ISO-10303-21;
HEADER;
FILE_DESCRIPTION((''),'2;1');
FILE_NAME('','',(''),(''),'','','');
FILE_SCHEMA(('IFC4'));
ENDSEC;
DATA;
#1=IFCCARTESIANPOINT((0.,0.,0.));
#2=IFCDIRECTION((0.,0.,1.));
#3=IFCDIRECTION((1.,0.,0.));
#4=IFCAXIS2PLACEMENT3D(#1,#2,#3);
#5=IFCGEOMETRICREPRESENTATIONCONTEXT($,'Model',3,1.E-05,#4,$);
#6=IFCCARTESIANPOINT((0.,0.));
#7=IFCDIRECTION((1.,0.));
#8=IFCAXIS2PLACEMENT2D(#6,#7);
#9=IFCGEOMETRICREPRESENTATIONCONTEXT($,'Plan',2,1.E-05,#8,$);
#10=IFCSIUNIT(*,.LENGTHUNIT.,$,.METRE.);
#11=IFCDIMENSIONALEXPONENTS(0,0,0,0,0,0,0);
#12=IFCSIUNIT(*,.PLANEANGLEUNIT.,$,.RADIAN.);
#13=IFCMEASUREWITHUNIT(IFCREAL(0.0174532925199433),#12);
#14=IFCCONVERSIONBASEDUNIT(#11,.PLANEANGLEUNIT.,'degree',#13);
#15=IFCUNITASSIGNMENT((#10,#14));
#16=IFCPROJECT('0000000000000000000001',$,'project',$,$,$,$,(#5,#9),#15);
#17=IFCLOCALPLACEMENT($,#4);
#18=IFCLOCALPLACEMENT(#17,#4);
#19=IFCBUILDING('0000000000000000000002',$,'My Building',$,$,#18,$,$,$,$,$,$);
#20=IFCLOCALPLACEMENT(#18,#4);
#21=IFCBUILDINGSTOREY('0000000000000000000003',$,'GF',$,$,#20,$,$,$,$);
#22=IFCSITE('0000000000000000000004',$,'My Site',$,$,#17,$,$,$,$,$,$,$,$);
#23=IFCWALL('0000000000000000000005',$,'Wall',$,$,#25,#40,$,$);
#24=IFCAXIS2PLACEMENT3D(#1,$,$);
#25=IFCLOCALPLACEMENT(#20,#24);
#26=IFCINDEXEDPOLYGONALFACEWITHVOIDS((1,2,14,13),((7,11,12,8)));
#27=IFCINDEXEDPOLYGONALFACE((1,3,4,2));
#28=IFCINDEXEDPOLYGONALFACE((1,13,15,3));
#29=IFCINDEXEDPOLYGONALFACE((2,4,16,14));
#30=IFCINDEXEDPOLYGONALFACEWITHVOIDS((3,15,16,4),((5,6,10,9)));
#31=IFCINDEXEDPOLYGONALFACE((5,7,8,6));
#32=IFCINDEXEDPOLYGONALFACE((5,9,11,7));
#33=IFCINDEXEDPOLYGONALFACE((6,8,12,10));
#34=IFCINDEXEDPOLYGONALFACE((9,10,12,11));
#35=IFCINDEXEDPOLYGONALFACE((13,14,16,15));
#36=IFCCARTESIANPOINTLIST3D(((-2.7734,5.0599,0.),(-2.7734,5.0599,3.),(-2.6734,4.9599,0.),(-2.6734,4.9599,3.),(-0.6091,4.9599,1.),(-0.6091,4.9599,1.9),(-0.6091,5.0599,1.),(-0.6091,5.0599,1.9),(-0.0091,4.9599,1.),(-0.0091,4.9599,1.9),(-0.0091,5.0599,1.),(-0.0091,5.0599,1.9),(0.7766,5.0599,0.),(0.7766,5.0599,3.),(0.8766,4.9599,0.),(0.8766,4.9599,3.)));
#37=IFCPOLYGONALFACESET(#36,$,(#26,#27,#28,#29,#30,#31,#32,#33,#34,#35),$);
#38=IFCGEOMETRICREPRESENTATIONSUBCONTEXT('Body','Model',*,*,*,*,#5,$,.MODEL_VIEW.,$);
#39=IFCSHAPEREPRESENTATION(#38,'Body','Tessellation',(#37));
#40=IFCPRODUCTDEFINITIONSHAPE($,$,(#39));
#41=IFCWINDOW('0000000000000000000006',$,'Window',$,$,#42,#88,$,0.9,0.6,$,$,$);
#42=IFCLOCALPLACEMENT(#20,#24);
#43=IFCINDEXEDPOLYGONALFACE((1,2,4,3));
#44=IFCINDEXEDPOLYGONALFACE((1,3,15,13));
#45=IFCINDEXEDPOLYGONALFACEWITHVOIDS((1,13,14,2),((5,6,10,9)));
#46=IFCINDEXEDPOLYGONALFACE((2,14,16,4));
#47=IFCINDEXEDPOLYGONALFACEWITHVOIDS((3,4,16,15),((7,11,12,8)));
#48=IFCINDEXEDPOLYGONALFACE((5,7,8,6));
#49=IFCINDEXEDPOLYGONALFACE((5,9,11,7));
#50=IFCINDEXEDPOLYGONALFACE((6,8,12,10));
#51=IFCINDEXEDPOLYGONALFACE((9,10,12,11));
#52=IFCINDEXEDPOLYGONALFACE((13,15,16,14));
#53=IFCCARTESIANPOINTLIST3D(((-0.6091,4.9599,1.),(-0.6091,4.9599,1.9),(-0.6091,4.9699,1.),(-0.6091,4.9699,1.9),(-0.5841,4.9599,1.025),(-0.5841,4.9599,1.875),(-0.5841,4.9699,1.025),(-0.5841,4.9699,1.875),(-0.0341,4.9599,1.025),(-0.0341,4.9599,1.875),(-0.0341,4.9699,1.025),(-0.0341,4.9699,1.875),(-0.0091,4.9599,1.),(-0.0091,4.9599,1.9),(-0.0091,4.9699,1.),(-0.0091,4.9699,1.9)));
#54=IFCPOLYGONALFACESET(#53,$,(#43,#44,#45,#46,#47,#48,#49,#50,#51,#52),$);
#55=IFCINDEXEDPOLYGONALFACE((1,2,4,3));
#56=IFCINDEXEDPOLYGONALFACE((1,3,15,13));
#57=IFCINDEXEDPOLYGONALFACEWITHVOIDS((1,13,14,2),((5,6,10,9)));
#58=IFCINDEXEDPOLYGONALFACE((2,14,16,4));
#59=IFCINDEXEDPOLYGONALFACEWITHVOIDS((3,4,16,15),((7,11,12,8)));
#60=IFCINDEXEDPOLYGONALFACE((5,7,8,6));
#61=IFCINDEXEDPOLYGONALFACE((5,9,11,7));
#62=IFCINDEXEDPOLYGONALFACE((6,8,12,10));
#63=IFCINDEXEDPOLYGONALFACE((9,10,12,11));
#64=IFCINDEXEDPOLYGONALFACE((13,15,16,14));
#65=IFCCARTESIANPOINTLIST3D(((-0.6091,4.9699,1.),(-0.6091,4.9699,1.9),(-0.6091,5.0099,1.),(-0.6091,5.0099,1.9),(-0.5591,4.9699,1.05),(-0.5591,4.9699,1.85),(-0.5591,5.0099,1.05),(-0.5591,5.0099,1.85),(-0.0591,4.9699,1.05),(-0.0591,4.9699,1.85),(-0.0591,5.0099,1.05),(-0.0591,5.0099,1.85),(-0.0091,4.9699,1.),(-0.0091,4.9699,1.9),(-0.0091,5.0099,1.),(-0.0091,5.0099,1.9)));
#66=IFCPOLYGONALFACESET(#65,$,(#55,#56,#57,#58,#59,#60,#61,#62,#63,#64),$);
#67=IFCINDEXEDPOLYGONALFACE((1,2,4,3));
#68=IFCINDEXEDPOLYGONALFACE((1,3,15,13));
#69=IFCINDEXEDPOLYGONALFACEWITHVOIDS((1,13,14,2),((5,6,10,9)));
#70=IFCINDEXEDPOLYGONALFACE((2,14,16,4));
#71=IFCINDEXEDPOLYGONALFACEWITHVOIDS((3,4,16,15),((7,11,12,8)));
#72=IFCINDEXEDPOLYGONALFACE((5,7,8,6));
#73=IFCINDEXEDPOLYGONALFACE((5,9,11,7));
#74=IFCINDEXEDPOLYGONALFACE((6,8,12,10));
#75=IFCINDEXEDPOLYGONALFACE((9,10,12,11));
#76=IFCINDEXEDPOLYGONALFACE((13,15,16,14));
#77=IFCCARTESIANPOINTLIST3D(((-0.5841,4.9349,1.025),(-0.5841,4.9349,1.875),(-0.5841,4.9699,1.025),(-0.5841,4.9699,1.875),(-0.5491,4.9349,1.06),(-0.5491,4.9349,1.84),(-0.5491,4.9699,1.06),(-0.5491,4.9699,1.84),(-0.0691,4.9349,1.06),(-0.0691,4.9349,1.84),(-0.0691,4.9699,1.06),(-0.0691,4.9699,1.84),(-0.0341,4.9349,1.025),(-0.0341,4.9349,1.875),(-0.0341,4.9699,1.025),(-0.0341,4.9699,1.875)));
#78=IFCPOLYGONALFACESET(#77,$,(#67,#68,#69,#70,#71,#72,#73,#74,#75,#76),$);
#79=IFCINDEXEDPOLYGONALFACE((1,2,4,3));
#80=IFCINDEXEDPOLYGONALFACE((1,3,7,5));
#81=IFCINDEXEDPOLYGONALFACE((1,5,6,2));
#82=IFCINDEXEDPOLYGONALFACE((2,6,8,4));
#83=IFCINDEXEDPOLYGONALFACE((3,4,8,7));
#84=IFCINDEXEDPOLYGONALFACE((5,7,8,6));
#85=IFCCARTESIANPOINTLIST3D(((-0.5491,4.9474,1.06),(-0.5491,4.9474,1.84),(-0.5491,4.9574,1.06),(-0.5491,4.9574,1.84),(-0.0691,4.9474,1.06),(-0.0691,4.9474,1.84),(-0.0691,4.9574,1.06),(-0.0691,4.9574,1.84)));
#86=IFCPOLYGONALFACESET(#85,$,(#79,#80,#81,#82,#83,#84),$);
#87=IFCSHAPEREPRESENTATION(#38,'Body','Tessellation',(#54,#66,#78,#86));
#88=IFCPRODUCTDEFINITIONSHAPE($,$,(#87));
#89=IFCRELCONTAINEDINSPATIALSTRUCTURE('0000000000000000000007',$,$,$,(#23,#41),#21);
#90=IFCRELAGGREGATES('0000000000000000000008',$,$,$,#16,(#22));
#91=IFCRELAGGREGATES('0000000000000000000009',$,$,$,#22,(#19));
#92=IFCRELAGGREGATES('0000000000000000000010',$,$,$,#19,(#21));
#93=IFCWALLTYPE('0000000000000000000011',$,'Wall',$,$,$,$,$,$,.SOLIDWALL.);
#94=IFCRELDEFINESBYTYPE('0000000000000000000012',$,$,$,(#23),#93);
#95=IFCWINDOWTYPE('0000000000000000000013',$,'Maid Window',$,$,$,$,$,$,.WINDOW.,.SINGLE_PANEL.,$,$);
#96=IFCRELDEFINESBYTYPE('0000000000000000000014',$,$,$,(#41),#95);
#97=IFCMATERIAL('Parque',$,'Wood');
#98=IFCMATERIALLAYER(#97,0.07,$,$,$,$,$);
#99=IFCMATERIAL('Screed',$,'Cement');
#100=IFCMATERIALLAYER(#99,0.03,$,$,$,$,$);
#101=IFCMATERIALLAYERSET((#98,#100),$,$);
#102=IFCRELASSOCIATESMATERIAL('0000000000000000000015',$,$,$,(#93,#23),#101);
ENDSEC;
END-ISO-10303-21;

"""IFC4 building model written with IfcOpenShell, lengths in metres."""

from ifc_helpers import new_model, entity, si_unit, converted_unit, frame, origin_with_axes, origin_2d_with_axis, place, context, subcontext, project, spatial, line, indexed_curve, outline, extrude, shape, source, transform, mapped, material, layer, layer_set, layer_usage, type_object, type_shapes, element, fill, save


model = new_model("IFC4")

# Units and contexts
model_context = context("Model", 3, precision=1e-05, world=origin_with_axes())
plan_context = context("Plan", 2, precision=1e-05, world=origin_2d_with_axis())
body_context_1 = subcontext(model_context, "Body", "Model", "MODEL_VIEW")
body_context_2 = subcontext(plan_context, "Body", "Plan", "PLAN_VIEW")
ifc_project = project(units=[si_unit("LENGTHUNIT", "METRE"), converted_unit("PLANEANGLEUNIT", "degree", entity("IfcReal", 0.0174532925199433), si_unit("PLANEANGLEUNIT", "RADIAN"), dimensions=[0, 0, 0, 0, 0, 0, 0])], contexts=[model_context, plan_context])

# Site, building, storey
site_placement = place(None, origin_with_axes())
site = spatial("IfcSite", under=ifc_project, at=site_placement, Name="My Site")
building_placement = place(site_placement, origin_with_axes())
building = spatial("IfcBuilding", under=site, at=building_placement, Name="My Building")
storey_placement = place(building_placement, origin_with_axes())
storey = spatial("IfcBuildingStorey", under=building, at=storey_placement, Name="GF")

# Shared definitions
ifc_material_1 = material(Name="Parque", Category="Wood")
ifc_layer_1 = layer(ifc_material_1, 0.07)
ifc_material_2 = material(Name="Screed", Category="Cement")
ifc_layer_2 = layer(ifc_material_2, 0.03)
ifc_layer_set_1 = layer_set([ifc_layer_1, ifc_layer_2])
wall_type = type_object("IfcWallType", Name="Wall", PredefinedType="SOLIDWALL", material=ifc_layer_set_1)

# Wall, opening, window
ifc_layer_usage_1 = layer_usage(ifc_layer_set_1, "AXIS2", "POSITIVE", 0.0)
wall_1_placement = place(storey_placement, frame((0.7766, 5.0599, 0.0), z_axis=(0.0, 0.0, 1.0), x_axis=(-1.0, 0.0, 0.0)))
wall_1 = element("IfcWall", 1, at=wall_1_placement, inside=storey, type_object=wall_type, material=ifc_layer_usage_1, Name="Wall", context=body_context_1, shape_type="SweptSolid", body=[
    extrude(outline(indexed_curve([(0.0, 0.0), (-0.1, 0.1), (3.45, 0.1), (3.55, 0.0)], segments=[line(1, 2, 3, 4, 1)])), origin_with_axes(), (0.0, 0.0, 1.0), 3.0),
])
shared_shape_1 = source(origin_with_axes(), body_context_1, "Body", "SweptSolid", [
    extrude(outline(indexed_curve([(0.0, 0.0), (0.6, 0.0), (0.6, 0.9), (0.0, 0.9)], segments=[line(1, 2, 3, 4, 1)])), frame((0.0, -0.6, 0.0), z_axis=(0.0, -1.0, 0.0), x_axis=(1.0, 0.0, 0.0)), (0.0, 0.0, -1.0), 1.2),
])
opening_1_placement = place(wall_1_placement, frame((0.7857, 0.0, 1.0), z_axis=(0.0, 0.0, 1.0), x_axis=(1.0, 0.0, 0.0)))
opening_1 = element("IfcOpeningElement", 2, at=opening_1_placement, cuts=wall_1, PredefinedType="OPENING", context=body_context_1, shape_type="MappedRepresentation", body=[
    mapped(shared_shape_1, transform((0.0, 0.0, 0.0), x_axis=(1.0, 0.0, 0.0), y_axis=(0.0, 1.0, 0.0), z_axis=(0.0, 0.0, 1.0), scale=1.0)),
])
window_type_1 = type_object("IfcWindowType", Name="Maid Window", PartitioningType="SINGLE_PANEL", PredefinedType="WINDOW")
shared_shape_2 = source(origin_with_axes(), body_context_1, "Body", "SweptSolid", [
    extrude(outline(indexed_curve([(0.0, 0.0), (0.6, 0.0), (0.6, 0.9), (0.0, 0.9)], segments=[line(1, 2, 3, 4, 1)]), holes=[indexed_curve([(0.025, 0.025), (0.575, 0.025), (0.575, 0.875), (0.025, 0.875)], segments=[line(1, 2, 3, 4, 1)])]), frame((0.0, 0.09, 0.0), z_axis=(0.0, -1.0, 0.0), x_axis=(1.0, 0.0, 0.0)), (0.0, 0.0, -1.0), 0.01),
    extrude(outline(indexed_curve([(0.0, 0.0), (0.6, 0.0), (0.6, 0.9), (0.0, 0.9)], segments=[line(1, 2, 3, 4, 1)]), holes=[indexed_curve([(0.05, 0.05), (0.55, 0.05), (0.55, 0.85), (0.05, 0.85)], segments=[line(1, 2, 3, 4, 1)])]), frame((0.0, 0.05, 0.0), z_axis=(0.0, -1.0, 0.0), x_axis=(1.0, 0.0, 0.0)), (0.0, 0.0, -1.0), 0.04),
    extrude(outline(indexed_curve([(0.0, 0.0), (0.55, 0.0), (0.55, 0.85), (0.0, 0.85)], segments=[line(1, 2, 3, 4, 1)]), holes=[indexed_curve([(0.035, 0.035), (0.515, 0.035), (0.515, 0.815), (0.035, 0.815)], segments=[line(1, 2, 3, 4, 1)])]), frame((0.025, 0.09, 0.025), z_axis=(0.0, -1.0, 0.0), x_axis=(1.0, 0.0, 0.0)), (0.0, 0.0, -1.0), 0.035),
    extrude(outline(indexed_curve([(0.035, 0.035), (0.515, 0.035), (0.515, 0.815), (0.035, 0.815)], segments=[line(1, 2, 3, 4, 1)])), frame((0.025, 0.1025, 0.025), z_axis=(0.0, -1.0, 0.0), x_axis=(1.0, 0.0, 0.0)), (0.0, 0.0, -1.0), 0.01),
])
shared_shape_3 = source(origin_with_axes(), body_context_2, "Body", "Curve2D", [
    entity("IfcIndexedPolyCurve", entity("IfcCartesianPointList2D", [[0.05, 0.05], [0.55, 0.05]])),
    entity("IfcIndexedPolyCurve", entity("IfcCartesianPointList2D", [[0.0, 0.1], [0.025, 0.1], [0.025, 0.09], [0.05, 0.09], [0.05, 0.05], [0.0, 0.05]]), [entity("IfcLineIndex", [1, 2, 3, 4, 5, 6, 1])]),
    entity("IfcIndexedPolyCurve", entity("IfcCartesianPointList2D", [[0.6, 0.1], [0.575, 0.1], [0.575, 0.09], [0.55, 0.09], [0.55, 0.05], [0.6, 0.05]]), [entity("IfcLineIndex", [1, 2, 3, 4, 5, 6, 1])]),
    entity("IfcIndexedPolyCurve", entity("IfcCartesianPointList2D", [[0.025, 0.09], [0.06, 0.09], [0.06, 0.125], [0.025, 0.125]]), [entity("IfcLineIndex", [1, 2, 3, 4, 1])]),
    entity("IfcIndexedPolyCurve", entity("IfcCartesianPointList2D", [[0.575, 0.09], [0.54, 0.09], [0.54, 0.125], [0.575, 0.125]]), [entity("IfcLineIndex", [1, 2, 3, 4, 1])]),
    entity("IfcIndexedPolyCurve", entity("IfcCartesianPointList2D", [[0.06, 0.09], [0.54, 0.09]])),
    entity("IfcIndexedPolyCurve", entity("IfcCartesianPointList2D", [[0.06, 0.125], [0.54, 0.125]])),
    entity("IfcIndexedPolyCurve", entity("IfcCartesianPointList2D", [[0.06, 0.1075], [0.54, 0.1075]])),
])
type_shapes(window_type_1, [shared_shape_2, shared_shape_3])
window_1_placement = place(opening_1_placement, frame((0.0, 0.0, 0.0), z_axis=(0.0, 0.0, 1.0), x_axis=(1.0, 0.0, 0.0)))
window_1 = element("IfcWindow", 3, at=window_1_placement, inside=storey, type_object=window_type_1, Name="Window", OverallHeight=0.9, OverallWidth=0.6, shapes=[
    shape(body_context_1, "Body", "MappedRepresentation", [mapped(shared_shape_2, transform((0.0, 0.0, 0.0), x_axis=(1.0, 0.0, 0.0), y_axis=(0.0, 1.0, 0.0), z_axis=(0.0, 0.0, 1.0), scale=1.0))]),
    shape(body_context_2, "Body", "MappedRepresentation", [mapped(shared_shape_3, transform((0.0, 0.0, 0.0), x_axis=(1.0, 0.0, 0.0), y_axis=(0.0, 1.0, 0.0), z_axis=(0.0, 0.0, 1.0), scale=1.0))]),
])
fill(opening_1, window_1)

save(model, "model.ifc")
